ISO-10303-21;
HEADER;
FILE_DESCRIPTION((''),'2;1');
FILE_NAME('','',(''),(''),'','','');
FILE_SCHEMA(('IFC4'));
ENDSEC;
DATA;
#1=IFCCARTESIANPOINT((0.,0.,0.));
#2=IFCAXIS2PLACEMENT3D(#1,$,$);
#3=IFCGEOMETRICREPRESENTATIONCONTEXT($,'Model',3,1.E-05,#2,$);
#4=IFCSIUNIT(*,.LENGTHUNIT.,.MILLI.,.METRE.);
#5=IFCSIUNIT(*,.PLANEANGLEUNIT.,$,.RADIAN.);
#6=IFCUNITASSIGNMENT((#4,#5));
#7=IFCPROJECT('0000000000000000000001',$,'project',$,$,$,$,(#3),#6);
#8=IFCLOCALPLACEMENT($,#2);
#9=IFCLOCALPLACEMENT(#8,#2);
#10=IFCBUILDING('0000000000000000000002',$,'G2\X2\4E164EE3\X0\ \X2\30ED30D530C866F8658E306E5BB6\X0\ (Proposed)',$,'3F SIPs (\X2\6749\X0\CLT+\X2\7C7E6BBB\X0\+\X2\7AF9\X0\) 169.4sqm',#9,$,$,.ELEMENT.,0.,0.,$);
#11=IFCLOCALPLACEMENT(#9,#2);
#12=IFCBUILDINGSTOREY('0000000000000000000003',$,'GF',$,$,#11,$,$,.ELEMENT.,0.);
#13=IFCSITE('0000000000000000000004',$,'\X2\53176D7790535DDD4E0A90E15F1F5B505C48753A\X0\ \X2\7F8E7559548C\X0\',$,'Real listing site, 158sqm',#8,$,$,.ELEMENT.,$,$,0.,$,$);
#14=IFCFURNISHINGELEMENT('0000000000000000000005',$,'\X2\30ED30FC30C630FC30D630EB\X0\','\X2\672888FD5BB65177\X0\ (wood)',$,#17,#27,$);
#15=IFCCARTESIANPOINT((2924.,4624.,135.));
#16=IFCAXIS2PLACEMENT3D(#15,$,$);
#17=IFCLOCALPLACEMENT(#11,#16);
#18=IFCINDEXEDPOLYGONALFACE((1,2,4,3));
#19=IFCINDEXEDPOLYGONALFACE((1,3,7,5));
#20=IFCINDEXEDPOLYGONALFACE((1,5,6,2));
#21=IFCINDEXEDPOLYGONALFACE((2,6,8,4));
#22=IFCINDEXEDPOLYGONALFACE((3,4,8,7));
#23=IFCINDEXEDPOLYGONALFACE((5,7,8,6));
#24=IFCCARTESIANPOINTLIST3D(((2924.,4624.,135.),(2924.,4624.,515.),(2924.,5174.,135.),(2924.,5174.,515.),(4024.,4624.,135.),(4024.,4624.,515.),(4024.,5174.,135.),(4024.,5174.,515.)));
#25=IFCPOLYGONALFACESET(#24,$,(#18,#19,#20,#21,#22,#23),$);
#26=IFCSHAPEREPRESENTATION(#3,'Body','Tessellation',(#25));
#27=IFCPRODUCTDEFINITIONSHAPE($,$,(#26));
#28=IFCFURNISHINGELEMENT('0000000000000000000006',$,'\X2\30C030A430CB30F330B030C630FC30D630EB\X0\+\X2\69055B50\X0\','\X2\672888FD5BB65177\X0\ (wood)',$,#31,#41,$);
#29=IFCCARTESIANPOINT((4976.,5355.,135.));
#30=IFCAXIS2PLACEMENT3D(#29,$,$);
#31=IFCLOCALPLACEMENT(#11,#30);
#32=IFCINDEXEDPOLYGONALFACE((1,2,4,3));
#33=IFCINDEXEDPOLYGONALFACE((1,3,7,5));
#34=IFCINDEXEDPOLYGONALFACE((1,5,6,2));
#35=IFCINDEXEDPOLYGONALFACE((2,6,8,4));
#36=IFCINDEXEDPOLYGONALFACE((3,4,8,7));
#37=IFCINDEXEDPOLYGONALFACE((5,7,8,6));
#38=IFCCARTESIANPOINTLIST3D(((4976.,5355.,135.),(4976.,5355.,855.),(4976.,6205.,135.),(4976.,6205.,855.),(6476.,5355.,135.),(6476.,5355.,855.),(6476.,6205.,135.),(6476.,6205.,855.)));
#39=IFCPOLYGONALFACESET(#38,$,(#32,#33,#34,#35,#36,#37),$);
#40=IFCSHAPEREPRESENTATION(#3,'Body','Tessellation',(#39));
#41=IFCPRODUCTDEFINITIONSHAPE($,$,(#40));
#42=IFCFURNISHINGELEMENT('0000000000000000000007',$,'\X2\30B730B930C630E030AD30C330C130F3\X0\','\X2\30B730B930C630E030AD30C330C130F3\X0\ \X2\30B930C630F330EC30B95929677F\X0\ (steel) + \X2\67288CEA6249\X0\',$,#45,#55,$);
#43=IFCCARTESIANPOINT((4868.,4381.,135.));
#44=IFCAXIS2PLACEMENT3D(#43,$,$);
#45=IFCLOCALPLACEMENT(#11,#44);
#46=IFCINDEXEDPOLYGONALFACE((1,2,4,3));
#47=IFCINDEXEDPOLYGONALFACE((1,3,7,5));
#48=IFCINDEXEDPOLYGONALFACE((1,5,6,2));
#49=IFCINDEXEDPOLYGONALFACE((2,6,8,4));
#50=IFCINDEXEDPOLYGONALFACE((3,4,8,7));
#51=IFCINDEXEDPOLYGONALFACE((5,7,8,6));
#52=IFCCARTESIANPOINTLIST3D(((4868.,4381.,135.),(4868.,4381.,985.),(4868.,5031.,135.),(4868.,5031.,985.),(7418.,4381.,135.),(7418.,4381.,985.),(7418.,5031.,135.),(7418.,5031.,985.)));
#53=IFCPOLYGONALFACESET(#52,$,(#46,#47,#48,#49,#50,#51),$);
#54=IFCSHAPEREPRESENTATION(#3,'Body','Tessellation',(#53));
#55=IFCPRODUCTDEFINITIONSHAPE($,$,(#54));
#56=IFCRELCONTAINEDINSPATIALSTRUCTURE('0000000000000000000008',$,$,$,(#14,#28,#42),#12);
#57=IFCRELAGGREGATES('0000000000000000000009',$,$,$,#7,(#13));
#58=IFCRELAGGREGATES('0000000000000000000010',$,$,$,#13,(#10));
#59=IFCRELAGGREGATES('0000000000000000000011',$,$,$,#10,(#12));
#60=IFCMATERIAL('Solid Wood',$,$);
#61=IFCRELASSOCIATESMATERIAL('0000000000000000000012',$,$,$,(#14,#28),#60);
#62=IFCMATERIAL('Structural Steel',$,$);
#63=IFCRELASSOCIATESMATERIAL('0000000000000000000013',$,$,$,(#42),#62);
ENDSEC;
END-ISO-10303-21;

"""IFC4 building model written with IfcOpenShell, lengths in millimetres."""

from ifc_helpers import new_model, si_unit, frame, frame_2d, origin, place, context, project, spatial, rectangle, extrude, material, element, save


model = new_model("IFC4")

# Units and contexts
model_context = context("Model", 3, precision=1e-05, world=origin())
ifc_project = project(units=[si_unit("LENGTHUNIT", "METRE", prefix="MILLI"), si_unit("PLANEANGLEUNIT", "RADIAN")], contexts=[model_context])

# Site, building, storey
site_placement = place(None, origin())
site = spatial("IfcSite", under=ifc_project, at=site_placement, Name="北海道川上郡弟子屈町 美留和", ObjectType="Real listing site, 158sqm", CompositionType="ELEMENT", RefElevation=0.0)
building_placement = place(site_placement, origin())
building = spatial("IfcBuilding", under=site, at=building_placement, Name="G2世代 ロフト書斎の家 (Proposed)", ObjectType="3F SIPs (杉CLT+籾殻+竹) 169.4sqm", CompositionType="ELEMENT", ElevationOfRefHeight=0.0, ElevationOfTerrain=0.0)
storey_placement = place(building_placement, origin())
storey = spatial("IfcBuildingStorey", under=building, at=storey_placement, Name="GF", CompositionType="ELEMENT", Elevation=0.0)

# Shared definitions
ifc_material_1 = material(Name="Solid Wood")

# Furnishing elements
furnishing_1_placement = place(storey_placement, frame((2924.0, 4624.0, 135.0)))
element("IfcFurnishingElement", 1, at=furnishing_1_placement, inside=storey, material=ifc_material_1, Name="ローテーブル", Description="木製家具 (wood)", context=model_context, shape_type="SweptSolid", body=[
    extrude(rectangle(XDim=1100.0, YDim=550.0, at=frame_2d((550.0, 275.0))), frame((2924.0, 4624.0, 135.0)), (0.0, 0.0, 1.0), 380.0),
])
furnishing_2_placement = place(storey_placement, frame((4976.0, 5355.0, 135.0)))
element("IfcFurnishingElement", 2, at=furnishing_2_placement, inside=storey, material=ifc_material_1, Name="ダイニングテーブル+椅子", Description="木製家具 (wood)", context=model_context, shape_type="SweptSolid", body=[
    extrude(rectangle(XDim=1500.0, YDim=850.0, at=frame_2d((750.0, 425.0))), frame((4976.0, 5355.0, 135.0)), (0.0, 0.0, 1.0), 720.0),
])
ifc_material_2 = material(Name="Structural Steel")
furnishing_3_placement = place(storey_placement, frame((4868.0, 4381.0, 135.0)))
element("IfcFurnishingElement", 3, at=furnishing_3_placement, inside=storey, material=ifc_material_2, Name="システムキッチン", Description="システムキッチン ステンレス天板 (steel) + 木質扉", context=model_context, shape_type="SweptSolid", body=[
    extrude(rectangle(XDim=2550.0, YDim=650.0, at=frame_2d((1275.0, 325.0))), frame((4868.0, 4381.0, 135.0)), (0.0, 0.0, 1.0), 850.0),
])

save(model, "model.ifc")
